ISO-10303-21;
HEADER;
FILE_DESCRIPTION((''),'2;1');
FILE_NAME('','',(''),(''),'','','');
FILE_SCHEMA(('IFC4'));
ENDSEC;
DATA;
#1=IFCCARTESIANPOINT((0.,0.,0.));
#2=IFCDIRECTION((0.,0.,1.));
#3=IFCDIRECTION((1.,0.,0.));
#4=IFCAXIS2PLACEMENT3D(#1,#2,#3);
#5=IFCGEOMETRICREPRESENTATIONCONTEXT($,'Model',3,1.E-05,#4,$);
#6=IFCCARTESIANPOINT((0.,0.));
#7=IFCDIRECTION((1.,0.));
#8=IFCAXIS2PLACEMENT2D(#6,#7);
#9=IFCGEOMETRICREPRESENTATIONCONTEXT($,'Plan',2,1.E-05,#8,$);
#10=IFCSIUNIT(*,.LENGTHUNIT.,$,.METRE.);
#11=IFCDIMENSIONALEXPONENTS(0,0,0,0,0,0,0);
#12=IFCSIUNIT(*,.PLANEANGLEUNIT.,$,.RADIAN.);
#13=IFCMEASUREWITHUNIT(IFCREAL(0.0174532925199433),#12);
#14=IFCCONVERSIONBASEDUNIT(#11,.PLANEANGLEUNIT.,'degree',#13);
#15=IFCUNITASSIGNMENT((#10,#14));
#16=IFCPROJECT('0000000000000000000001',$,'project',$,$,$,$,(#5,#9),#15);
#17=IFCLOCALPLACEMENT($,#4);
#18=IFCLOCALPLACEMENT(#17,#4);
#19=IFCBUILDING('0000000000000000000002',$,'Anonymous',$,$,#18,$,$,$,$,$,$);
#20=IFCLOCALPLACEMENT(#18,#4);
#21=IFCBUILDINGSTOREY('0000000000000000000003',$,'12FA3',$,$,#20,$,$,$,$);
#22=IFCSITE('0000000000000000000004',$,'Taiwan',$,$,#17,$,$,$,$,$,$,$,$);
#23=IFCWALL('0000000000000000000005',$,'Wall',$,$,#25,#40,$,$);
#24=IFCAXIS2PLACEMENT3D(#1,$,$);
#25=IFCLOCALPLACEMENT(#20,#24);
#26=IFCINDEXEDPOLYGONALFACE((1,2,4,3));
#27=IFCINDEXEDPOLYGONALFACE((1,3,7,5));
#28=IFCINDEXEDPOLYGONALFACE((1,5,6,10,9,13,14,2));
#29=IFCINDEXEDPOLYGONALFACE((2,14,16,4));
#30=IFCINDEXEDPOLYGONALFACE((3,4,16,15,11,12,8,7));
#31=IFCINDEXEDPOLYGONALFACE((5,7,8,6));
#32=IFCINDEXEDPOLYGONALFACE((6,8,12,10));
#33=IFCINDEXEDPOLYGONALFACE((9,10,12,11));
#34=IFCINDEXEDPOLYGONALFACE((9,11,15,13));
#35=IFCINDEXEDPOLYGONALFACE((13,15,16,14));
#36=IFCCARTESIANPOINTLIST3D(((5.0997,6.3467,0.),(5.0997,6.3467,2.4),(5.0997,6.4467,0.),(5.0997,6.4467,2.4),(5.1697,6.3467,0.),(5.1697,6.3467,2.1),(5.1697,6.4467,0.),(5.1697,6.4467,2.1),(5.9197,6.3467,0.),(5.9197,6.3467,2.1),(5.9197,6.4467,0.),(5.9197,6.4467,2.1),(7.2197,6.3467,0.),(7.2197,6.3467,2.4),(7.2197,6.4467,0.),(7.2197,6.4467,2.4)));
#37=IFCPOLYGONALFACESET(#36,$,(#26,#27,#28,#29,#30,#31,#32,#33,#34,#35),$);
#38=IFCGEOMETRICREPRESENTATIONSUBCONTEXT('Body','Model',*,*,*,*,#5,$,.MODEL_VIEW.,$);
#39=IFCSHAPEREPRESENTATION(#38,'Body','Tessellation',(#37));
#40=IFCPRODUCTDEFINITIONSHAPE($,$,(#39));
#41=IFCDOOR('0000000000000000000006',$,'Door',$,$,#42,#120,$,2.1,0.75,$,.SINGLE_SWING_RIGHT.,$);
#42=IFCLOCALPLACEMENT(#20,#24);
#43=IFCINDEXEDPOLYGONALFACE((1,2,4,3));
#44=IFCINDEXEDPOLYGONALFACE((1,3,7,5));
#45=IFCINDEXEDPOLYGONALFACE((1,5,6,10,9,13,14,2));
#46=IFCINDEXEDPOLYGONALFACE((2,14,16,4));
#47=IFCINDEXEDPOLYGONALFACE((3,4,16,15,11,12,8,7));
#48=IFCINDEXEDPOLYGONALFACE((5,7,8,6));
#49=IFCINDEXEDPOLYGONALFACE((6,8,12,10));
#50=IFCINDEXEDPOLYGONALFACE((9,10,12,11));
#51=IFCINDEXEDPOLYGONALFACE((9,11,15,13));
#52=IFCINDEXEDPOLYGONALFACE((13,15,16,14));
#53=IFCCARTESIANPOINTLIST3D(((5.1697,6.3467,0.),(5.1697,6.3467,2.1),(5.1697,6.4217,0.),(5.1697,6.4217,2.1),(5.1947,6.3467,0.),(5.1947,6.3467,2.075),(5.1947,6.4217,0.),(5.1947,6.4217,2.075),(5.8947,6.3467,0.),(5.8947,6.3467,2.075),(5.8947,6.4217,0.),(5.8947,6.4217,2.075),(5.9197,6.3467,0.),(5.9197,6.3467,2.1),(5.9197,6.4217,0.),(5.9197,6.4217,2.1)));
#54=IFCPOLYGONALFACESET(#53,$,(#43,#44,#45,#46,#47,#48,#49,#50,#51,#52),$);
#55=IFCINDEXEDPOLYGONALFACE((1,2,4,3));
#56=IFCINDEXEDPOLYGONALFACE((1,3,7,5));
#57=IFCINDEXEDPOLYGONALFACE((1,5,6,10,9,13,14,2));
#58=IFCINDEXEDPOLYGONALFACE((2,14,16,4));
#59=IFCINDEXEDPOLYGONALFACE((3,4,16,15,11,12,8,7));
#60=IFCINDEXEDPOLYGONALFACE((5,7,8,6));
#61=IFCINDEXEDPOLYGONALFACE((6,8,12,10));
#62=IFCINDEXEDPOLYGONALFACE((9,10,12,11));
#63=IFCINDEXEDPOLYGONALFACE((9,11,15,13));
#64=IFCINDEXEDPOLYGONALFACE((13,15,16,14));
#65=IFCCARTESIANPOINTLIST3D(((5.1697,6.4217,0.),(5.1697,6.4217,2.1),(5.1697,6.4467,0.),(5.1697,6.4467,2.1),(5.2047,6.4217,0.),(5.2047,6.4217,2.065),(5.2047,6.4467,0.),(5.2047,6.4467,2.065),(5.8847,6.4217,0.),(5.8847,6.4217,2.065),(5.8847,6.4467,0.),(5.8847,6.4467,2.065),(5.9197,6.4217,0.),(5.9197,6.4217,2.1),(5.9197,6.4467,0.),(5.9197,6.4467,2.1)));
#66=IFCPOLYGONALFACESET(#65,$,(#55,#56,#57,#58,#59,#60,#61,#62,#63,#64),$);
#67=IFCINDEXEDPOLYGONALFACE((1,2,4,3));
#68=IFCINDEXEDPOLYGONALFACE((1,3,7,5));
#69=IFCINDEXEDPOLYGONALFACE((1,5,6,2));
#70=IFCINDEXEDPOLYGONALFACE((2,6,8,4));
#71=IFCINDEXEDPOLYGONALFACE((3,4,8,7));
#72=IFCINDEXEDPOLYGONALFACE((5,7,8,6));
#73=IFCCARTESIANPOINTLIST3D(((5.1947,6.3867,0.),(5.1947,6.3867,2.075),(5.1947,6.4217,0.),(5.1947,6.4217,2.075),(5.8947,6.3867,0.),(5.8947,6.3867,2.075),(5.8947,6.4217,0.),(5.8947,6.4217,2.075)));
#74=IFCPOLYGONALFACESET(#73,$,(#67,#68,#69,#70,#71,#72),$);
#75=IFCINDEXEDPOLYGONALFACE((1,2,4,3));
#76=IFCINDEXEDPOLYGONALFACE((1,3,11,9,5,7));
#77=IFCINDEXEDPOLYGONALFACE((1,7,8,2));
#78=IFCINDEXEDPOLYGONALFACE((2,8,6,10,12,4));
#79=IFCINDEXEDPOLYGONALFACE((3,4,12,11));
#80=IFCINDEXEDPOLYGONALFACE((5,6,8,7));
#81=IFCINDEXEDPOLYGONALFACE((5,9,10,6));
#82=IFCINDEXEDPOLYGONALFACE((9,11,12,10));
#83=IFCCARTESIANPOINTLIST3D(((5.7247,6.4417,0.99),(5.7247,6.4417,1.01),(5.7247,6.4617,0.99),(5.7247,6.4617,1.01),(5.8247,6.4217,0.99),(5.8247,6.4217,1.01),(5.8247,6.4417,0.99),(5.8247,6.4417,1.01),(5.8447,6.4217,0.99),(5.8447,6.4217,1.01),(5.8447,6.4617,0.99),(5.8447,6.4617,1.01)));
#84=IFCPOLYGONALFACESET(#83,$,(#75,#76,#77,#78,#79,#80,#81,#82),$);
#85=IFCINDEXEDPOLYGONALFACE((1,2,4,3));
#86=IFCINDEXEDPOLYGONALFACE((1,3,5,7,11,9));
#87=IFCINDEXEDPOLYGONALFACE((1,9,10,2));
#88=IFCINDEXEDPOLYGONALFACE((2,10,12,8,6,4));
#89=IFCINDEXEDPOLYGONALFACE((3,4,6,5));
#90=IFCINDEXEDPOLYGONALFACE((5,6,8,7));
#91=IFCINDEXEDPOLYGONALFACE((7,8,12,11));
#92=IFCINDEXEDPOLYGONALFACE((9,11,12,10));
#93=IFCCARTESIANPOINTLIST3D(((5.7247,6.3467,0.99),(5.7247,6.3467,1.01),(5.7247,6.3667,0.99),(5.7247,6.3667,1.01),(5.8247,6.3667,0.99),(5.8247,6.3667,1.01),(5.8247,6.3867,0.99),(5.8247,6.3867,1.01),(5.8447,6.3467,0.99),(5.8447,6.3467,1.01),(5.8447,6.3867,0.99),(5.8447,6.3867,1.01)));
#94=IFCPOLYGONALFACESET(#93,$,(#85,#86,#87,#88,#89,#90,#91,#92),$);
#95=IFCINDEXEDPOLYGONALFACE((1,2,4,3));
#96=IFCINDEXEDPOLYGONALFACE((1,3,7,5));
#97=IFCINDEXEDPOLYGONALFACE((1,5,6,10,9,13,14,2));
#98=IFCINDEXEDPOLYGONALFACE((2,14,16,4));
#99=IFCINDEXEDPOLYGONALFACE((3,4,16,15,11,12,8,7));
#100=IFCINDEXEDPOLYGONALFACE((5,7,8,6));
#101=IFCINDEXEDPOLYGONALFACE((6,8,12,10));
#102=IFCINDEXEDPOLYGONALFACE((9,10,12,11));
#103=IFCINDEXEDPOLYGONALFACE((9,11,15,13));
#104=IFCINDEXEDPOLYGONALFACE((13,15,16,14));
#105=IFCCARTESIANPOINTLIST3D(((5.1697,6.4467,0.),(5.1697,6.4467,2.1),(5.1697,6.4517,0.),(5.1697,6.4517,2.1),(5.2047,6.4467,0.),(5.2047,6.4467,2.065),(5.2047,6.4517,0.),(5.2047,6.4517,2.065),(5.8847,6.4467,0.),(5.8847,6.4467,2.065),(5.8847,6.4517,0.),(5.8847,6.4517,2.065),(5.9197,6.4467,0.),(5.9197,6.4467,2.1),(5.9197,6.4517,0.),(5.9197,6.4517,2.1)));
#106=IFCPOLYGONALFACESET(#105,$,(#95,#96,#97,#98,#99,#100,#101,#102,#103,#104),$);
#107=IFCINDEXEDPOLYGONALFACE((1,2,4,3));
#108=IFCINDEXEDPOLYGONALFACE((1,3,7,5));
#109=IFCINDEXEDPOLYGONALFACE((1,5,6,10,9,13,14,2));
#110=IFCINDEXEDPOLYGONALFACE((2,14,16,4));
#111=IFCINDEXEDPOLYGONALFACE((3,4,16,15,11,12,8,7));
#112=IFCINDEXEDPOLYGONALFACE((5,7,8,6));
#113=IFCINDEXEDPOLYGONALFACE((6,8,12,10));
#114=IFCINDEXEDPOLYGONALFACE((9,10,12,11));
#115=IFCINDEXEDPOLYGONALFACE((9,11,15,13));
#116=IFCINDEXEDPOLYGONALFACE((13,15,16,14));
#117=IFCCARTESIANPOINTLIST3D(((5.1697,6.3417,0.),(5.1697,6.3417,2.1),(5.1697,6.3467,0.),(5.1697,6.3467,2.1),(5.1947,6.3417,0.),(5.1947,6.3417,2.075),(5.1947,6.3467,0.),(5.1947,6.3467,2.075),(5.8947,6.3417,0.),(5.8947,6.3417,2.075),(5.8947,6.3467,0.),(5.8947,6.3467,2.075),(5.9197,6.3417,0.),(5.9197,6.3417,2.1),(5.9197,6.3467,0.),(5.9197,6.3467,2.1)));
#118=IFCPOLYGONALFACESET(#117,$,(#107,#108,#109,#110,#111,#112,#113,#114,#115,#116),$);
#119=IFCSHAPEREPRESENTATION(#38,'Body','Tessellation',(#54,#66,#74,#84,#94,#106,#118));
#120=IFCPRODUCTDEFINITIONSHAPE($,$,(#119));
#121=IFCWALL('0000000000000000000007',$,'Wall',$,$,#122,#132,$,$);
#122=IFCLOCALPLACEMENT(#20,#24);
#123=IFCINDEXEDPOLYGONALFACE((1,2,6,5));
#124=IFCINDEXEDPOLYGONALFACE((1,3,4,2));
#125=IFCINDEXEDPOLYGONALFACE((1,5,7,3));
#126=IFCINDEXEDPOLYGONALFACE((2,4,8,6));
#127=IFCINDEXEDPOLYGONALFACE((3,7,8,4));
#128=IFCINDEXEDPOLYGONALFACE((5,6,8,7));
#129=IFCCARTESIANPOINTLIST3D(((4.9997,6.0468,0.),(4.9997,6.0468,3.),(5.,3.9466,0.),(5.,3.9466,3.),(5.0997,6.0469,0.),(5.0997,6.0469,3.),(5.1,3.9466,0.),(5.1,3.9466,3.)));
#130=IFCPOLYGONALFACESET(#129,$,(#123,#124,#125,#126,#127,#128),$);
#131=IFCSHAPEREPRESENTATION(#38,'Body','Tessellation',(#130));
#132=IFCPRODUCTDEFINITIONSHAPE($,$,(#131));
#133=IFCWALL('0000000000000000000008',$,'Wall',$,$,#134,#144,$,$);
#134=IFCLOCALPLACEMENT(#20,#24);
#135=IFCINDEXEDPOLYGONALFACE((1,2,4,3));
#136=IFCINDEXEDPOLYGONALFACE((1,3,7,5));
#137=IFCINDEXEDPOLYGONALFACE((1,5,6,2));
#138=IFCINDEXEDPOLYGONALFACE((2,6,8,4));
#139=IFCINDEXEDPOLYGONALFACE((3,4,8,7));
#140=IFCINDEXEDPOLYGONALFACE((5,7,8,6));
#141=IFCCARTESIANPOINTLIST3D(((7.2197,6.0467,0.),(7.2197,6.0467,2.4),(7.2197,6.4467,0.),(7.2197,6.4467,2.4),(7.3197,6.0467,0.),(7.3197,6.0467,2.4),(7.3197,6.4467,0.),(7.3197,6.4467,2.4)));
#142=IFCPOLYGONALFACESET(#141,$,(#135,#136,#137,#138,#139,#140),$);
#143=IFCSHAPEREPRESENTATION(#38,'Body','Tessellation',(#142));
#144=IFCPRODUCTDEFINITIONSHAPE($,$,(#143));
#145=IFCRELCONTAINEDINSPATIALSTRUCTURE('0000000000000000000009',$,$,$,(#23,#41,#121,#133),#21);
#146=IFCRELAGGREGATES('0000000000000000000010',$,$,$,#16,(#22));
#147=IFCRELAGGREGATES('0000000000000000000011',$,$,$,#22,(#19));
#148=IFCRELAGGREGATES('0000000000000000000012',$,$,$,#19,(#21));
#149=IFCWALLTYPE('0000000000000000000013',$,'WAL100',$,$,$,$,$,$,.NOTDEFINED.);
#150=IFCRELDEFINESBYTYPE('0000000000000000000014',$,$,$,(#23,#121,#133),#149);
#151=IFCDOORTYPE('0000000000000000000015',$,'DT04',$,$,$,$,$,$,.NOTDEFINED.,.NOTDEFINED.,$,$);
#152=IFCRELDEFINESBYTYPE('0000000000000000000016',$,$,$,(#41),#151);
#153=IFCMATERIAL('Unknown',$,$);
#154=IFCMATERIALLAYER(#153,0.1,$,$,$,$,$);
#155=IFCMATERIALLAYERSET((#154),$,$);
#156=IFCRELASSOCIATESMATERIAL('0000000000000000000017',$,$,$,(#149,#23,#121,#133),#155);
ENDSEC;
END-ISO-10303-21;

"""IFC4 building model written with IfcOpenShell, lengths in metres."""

from ifc_helpers import new_model, entity, si_unit, converted_unit, frame, origin_with_axes, origin_2d_with_axis, place, context, subcontext, project, spatial, line, indexed_curve, outline, extrude, shape, source, transform, mapped, material, layer, layer_set, layer_usage, type_object, type_shapes, element, fill, save


model = new_model("IFC4")

# Units and contexts
model_context = context("Model", 3, precision=1e-05, world=origin_with_axes())
plan_context = context("Plan", 2, precision=1e-05, world=origin_2d_with_axis())
body_context_1 = subcontext(model_context, "Body", "Model", "MODEL_VIEW")
body_context_2 = subcontext(plan_context, "Body", "Plan", "PLAN_VIEW")
ifc_project = project(units=[si_unit("LENGTHUNIT", "METRE"), converted_unit("PLANEANGLEUNIT", "degree", entity("IfcReal", 0.0174532925199433), si_unit("PLANEANGLEUNIT", "RADIAN"), dimensions=[0, 0, 0, 0, 0, 0, 0])], contexts=[model_context, plan_context])

# Site, building, storey
site_placement = place(None, origin_with_axes())
site = spatial("IfcSite", under=ifc_project, at=site_placement, Name="Taiwan")
building_placement = place(site_placement, origin_with_axes())
building = spatial("IfcBuilding", under=site, at=building_placement, Name="Anonymous")
storey_placement = place(building_placement, origin_with_axes())
storey = spatial("IfcBuildingStorey", under=building, at=storey_placement, Name="12FA3")

# Shared definitions
ifc_material = material(Name="Unknown")

# Shared definitions
ifc_layer_1 = layer(ifc_material, 0.1)
ifc_layer_set_1 = layer_set([ifc_layer_1])
wall_type_1 = type_object("IfcWallType", Name="WAL100", PredefinedType="NOTDEFINED", material=ifc_layer_set_1)

# Wall, opening, door
ifc_layer_usage_1 = layer_usage(ifc_layer_set_1, "AXIS2", "POSITIVE", 0.0)
wall_1_placement = place(storey_placement, frame((7.2197, 6.4467, 0.0), z_axis=(0.0, 0.0, 1.0), x_axis=(-1.0, 0.0, 0.0)))
wall_1 = element("IfcWall", 1, at=wall_1_placement, inside=storey, type_object=wall_type_1, material=ifc_layer_usage_1, Name="Wall", context=body_context_1, shape_type="SweptSolid", body=[
    extrude(outline(indexed_curve([(0.0, 0.0), (0.0, 0.1), (2.12, 0.1), (2.12, 0.0)], segments=[line(1, 2, 3, 4, 1)])), origin_with_axes(), (0.0, 0.0, 1.0), 2.4),
])
shared_shape_1 = source(origin_with_axes(), body_context_1, "Body", "SweptSolid", [
    extrude(outline(indexed_curve([(0.0, 0.0), (0.75, 0.0), (0.75, 2.1), (0.0, 2.1)], segments=[line(1, 2, 3, 4, 1)])), frame((0.0, -0.6, 0.0), z_axis=(0.0, -1.0, 0.0), x_axis=(1.0, 0.0, 0.0)), (0.0, 0.0, -1.0), 1.2),
])
opening_1_placement = place(wall_1_placement, frame((1.3, 0.0, 0.0), z_axis=(0.0, 0.0, 1.0), x_axis=(1.0, 0.0, 0.0)))
opening_1 = element("IfcOpeningElement", 2, at=opening_1_placement, cuts=wall_1, PredefinedType="OPENING", context=body_context_1, shape_type="MappedRepresentation", body=[
    mapped(shared_shape_1, transform((0.0, 0.0, 0.0), x_axis=(1.0, 0.0, 0.0), y_axis=(0.0, 1.0, 0.0), z_axis=(0.0, 0.0, 1.0), scale=1.0)),
])
door_type_1 = type_object("IfcDoorType", Name="DT04", OperationType="NOTDEFINED", PredefinedType="NOTDEFINED")
shared_shape_2 = source(origin_with_axes(), body_context_1, "Body", "SweptSolid", [
    extrude(outline(indexed_curve([(0.0, 0.0), (0.0, 2.1), (0.75, 2.1), (0.75, 0.0), (0.725, 0.0), (0.725, 2.075), (0.025, 2.075), (0.025, 0.0)], segments=[line(1, 2, 3, 4, 5, 6, 7, 8, 1)])), frame((0.0, 0.025, 0.0), z_axis=(0.0, -1.0, 0.0), x_axis=(1.0, 0.0, 0.0)), (0.0, 0.0, -1.0), 0.075),
    extrude(outline(indexed_curve([(0.0, 0.0), (0.0, 2.1), (0.75, 2.1), (0.75, 0.0), (0.715, 0.0), (0.715, 2.065), (0.035, 2.065), (0.035, 0.0)], segments=[line(1, 2, 3, 4, 5, 6, 7, 8, 1)])), frame((0.0, 0.0, 0.0), z_axis=(0.0, -1.0, 0.0), x_axis=(1.0, 0.0, 0.0)), (0.0, 0.0, -1.0), 0.025),
    extrude(outline(indexed_curve([(0.0, 0.0), (0.7, 0.0), (0.7, 0.035), (0.0, 0.035)], segments=[line(1, 2, 3, 4, 1)])), frame((0.025, 0.025, 0.0), z_axis=(0.0, 0.0, 1.0), x_axis=(1.0, 0.0, 0.0)), (0.0, 0.0, 1.0), 2.075),
    extrude(outline(indexed_curve([(0.0, 0.0), (0.0, -0.04), (0.12, -0.04), (0.12, -0.02), (0.02, -0.02), (0.02, 0.0)], segments=[line(1, 2, 3, 4, 5, 6, 1)])), frame((0.075, 0.025, 0.99), z_axis=(0.0, 0.0, 1.0), x_axis=(1.0, 0.0, 0.0)), (0.0, 0.0, 1.0), 0.02),
    extrude(outline(indexed_curve([(0.0, 0.0), (0.0, 0.04), (0.12, 0.04), (0.12, 0.02), (0.02, 0.02), (0.02, 0.0)], segments=[line(1, 2, 3, 4, 5, 6, 1)])), frame((0.075, 0.06, 0.99), z_axis=(0.0, 0.0, 1.0), x_axis=(1.0, 0.0, 0.0)), (0.0, 0.0, 1.0), 0.02),
    extrude(outline(indexed_curve([(0.0, 0.0), (0.0, 2.1), (0.75, 2.1), (0.75, 0.0), (0.715, 0.0), (0.715, 2.065), (0.035, 2.065), (0.035, 0.0)], segments=[line(1, 2, 3, 4, 5, 6, 7, 8, 1)])), frame((0.0, -0.005, 0.0), z_axis=(0.0, -1.0, 0.0), x_axis=(1.0, 0.0, 0.0)), (0.0, 0.0, -1.0), 0.005),
    extrude(outline(indexed_curve([(0.0, 0.0), (0.0, 2.1), (0.75, 2.1), (0.75, 0.0), (0.725, 0.0), (0.725, 2.075), (0.025, 2.075), (0.025, 0.0)], segments=[line(1, 2, 3, 4, 5, 6, 7, 8, 1)])), frame((0.0, 0.1, 0.0), z_axis=(0.0, -1.0, 0.0), x_axis=(1.0, 0.0, 0.0)), (0.0, 0.0, -1.0), 0.005),
])
shared_shape_3 = source(origin_with_axes(), body_context_2, "Body", "Curve2D", [
    entity("IfcIndexedPolyCurve", entity("IfcCartesianPointList2D", [[0.0, 0.0], [0.0, 0.1], [0.025, 0.1], [0.025, 0.025], [0.035, 0.025], [0.035, 0.0]]), [entity("IfcLineIndex", [1, 2, 3, 4, 5, 6, 1])]),
    entity("IfcIndexedPolyCurve", entity("IfcCartesianPointList2D", [[0.75, 0.0], [0.75, 0.1], [0.725, 0.1], [0.725, 0.025], [0.715, 0.025], [0.715, 0.0]]), [entity("IfcLineIndex", [1, 2, 3, 4, 5, 6, 1])]),
    entity("IfcTrimmedCurve", entity("IfcEllipse", entity("IfcAxis2Placement2D", entity("IfcCartesianPoint", [0.69, 0.1]), entity("IfcDirection", [1.0, 0.0])), 0.665, 0.7), [entity("IfcCartesianPoint", [0.69, 0.8])], [entity("IfcCartesianPoint", [0.025, 0.1])], True, "CARTESIAN"),
    entity("IfcIndexedPolyCurve", entity("IfcCartesianPointList2D", [[0.725, 0.1], [0.69, 0.1], [0.69, 0.8], [0.725, 0.8]]), [entity("IfcLineIndex", [1, 2, 3, 4, 1])]),
])
type_shapes(door_type_1, [shared_shape_2, shared_shape_3])
door_1_placement = place(opening_1_placement, frame((0.0, 0.0, 0.0), z_axis=(0.0, 0.0, 1.0), x_axis=(1.0, 0.0, 0.0)))
door_1 = element("IfcDoor", 3, at=door_1_placement, inside=storey, type_object=door_type_1, Name="Door", OperationType="SINGLE_SWING_RIGHT", OverallHeight=2.1, OverallWidth=0.75, shapes=[
    shape(body_context_1, "Body", "MappedRepresentation", [mapped(shared_shape_2, transform((0.0, 0.0, 0.0), x_axis=(1.0, 0.0, 0.0), y_axis=(0.0, 1.0, 0.0), z_axis=(0.0, 0.0, 1.0), scale=1.0))]),
    shape(body_context_2, "Body", "MappedRepresentation", [mapped(shared_shape_3, transform((0.0, 0.0, 0.0), x_axis=(1.0, 0.0, 0.0), y_axis=(0.0, 1.0, 0.0), z_axis=(0.0, 0.0, 1.0), scale=1.0))]),
])
fill(opening_1, door_1)

# Walls
ifc_layer_usage_2 = layer_usage(ifc_layer_set_1, "AXIS2", "POSITIVE", 0.0)
wall_2_placement = place(storey_placement, frame((4.9997, 6.0468, 0.0), z_axis=(0.0, 0.0, 1.0), x_axis=(0.000135, -1.0, 0.0)))
element("IfcWall", 4, at=wall_2_placement, inside=storey, type_object=wall_type_1, material=ifc_layer_usage_2, Name="Wall", context=body_context_1, shape_type="SweptSolid", body=[
    extrude(outline(indexed_curve([(0.0, 0.0), (0.0, 0.1), (2.1002, 0.1), (2.1002, 0.0)], segments=[line(1, 2, 3, 4, 1)])), origin_with_axes(), (0.0, 0.0, 1.0), 3.0),
])
ifc_layer_usage_3 = layer_usage(ifc_layer_set_1, "AXIS2", "POSITIVE", 0.0)
wall_3_placement = place(storey_placement, frame((7.3197, 6.0467, 0.0), z_axis=(0.0, 0.0, 1.0), x_axis=(0.0, 1.0, 0.0)))
element("IfcWall", 5, at=wall_3_placement, inside=storey, type_object=wall_type_1, material=ifc_layer_usage_3, Name="Wall", context=body_context_1, shape_type="SweptSolid", body=[
    extrude(outline(indexed_curve([(0.0, 0.0), (0.0, 0.1), (0.4, 0.1), (0.4, 0.0)], segments=[line(1, 2, 3, 4, 1)])), origin_with_axes(), (0.0, 0.0, 1.0), 2.4),
])

save(model, "model.ifc")
